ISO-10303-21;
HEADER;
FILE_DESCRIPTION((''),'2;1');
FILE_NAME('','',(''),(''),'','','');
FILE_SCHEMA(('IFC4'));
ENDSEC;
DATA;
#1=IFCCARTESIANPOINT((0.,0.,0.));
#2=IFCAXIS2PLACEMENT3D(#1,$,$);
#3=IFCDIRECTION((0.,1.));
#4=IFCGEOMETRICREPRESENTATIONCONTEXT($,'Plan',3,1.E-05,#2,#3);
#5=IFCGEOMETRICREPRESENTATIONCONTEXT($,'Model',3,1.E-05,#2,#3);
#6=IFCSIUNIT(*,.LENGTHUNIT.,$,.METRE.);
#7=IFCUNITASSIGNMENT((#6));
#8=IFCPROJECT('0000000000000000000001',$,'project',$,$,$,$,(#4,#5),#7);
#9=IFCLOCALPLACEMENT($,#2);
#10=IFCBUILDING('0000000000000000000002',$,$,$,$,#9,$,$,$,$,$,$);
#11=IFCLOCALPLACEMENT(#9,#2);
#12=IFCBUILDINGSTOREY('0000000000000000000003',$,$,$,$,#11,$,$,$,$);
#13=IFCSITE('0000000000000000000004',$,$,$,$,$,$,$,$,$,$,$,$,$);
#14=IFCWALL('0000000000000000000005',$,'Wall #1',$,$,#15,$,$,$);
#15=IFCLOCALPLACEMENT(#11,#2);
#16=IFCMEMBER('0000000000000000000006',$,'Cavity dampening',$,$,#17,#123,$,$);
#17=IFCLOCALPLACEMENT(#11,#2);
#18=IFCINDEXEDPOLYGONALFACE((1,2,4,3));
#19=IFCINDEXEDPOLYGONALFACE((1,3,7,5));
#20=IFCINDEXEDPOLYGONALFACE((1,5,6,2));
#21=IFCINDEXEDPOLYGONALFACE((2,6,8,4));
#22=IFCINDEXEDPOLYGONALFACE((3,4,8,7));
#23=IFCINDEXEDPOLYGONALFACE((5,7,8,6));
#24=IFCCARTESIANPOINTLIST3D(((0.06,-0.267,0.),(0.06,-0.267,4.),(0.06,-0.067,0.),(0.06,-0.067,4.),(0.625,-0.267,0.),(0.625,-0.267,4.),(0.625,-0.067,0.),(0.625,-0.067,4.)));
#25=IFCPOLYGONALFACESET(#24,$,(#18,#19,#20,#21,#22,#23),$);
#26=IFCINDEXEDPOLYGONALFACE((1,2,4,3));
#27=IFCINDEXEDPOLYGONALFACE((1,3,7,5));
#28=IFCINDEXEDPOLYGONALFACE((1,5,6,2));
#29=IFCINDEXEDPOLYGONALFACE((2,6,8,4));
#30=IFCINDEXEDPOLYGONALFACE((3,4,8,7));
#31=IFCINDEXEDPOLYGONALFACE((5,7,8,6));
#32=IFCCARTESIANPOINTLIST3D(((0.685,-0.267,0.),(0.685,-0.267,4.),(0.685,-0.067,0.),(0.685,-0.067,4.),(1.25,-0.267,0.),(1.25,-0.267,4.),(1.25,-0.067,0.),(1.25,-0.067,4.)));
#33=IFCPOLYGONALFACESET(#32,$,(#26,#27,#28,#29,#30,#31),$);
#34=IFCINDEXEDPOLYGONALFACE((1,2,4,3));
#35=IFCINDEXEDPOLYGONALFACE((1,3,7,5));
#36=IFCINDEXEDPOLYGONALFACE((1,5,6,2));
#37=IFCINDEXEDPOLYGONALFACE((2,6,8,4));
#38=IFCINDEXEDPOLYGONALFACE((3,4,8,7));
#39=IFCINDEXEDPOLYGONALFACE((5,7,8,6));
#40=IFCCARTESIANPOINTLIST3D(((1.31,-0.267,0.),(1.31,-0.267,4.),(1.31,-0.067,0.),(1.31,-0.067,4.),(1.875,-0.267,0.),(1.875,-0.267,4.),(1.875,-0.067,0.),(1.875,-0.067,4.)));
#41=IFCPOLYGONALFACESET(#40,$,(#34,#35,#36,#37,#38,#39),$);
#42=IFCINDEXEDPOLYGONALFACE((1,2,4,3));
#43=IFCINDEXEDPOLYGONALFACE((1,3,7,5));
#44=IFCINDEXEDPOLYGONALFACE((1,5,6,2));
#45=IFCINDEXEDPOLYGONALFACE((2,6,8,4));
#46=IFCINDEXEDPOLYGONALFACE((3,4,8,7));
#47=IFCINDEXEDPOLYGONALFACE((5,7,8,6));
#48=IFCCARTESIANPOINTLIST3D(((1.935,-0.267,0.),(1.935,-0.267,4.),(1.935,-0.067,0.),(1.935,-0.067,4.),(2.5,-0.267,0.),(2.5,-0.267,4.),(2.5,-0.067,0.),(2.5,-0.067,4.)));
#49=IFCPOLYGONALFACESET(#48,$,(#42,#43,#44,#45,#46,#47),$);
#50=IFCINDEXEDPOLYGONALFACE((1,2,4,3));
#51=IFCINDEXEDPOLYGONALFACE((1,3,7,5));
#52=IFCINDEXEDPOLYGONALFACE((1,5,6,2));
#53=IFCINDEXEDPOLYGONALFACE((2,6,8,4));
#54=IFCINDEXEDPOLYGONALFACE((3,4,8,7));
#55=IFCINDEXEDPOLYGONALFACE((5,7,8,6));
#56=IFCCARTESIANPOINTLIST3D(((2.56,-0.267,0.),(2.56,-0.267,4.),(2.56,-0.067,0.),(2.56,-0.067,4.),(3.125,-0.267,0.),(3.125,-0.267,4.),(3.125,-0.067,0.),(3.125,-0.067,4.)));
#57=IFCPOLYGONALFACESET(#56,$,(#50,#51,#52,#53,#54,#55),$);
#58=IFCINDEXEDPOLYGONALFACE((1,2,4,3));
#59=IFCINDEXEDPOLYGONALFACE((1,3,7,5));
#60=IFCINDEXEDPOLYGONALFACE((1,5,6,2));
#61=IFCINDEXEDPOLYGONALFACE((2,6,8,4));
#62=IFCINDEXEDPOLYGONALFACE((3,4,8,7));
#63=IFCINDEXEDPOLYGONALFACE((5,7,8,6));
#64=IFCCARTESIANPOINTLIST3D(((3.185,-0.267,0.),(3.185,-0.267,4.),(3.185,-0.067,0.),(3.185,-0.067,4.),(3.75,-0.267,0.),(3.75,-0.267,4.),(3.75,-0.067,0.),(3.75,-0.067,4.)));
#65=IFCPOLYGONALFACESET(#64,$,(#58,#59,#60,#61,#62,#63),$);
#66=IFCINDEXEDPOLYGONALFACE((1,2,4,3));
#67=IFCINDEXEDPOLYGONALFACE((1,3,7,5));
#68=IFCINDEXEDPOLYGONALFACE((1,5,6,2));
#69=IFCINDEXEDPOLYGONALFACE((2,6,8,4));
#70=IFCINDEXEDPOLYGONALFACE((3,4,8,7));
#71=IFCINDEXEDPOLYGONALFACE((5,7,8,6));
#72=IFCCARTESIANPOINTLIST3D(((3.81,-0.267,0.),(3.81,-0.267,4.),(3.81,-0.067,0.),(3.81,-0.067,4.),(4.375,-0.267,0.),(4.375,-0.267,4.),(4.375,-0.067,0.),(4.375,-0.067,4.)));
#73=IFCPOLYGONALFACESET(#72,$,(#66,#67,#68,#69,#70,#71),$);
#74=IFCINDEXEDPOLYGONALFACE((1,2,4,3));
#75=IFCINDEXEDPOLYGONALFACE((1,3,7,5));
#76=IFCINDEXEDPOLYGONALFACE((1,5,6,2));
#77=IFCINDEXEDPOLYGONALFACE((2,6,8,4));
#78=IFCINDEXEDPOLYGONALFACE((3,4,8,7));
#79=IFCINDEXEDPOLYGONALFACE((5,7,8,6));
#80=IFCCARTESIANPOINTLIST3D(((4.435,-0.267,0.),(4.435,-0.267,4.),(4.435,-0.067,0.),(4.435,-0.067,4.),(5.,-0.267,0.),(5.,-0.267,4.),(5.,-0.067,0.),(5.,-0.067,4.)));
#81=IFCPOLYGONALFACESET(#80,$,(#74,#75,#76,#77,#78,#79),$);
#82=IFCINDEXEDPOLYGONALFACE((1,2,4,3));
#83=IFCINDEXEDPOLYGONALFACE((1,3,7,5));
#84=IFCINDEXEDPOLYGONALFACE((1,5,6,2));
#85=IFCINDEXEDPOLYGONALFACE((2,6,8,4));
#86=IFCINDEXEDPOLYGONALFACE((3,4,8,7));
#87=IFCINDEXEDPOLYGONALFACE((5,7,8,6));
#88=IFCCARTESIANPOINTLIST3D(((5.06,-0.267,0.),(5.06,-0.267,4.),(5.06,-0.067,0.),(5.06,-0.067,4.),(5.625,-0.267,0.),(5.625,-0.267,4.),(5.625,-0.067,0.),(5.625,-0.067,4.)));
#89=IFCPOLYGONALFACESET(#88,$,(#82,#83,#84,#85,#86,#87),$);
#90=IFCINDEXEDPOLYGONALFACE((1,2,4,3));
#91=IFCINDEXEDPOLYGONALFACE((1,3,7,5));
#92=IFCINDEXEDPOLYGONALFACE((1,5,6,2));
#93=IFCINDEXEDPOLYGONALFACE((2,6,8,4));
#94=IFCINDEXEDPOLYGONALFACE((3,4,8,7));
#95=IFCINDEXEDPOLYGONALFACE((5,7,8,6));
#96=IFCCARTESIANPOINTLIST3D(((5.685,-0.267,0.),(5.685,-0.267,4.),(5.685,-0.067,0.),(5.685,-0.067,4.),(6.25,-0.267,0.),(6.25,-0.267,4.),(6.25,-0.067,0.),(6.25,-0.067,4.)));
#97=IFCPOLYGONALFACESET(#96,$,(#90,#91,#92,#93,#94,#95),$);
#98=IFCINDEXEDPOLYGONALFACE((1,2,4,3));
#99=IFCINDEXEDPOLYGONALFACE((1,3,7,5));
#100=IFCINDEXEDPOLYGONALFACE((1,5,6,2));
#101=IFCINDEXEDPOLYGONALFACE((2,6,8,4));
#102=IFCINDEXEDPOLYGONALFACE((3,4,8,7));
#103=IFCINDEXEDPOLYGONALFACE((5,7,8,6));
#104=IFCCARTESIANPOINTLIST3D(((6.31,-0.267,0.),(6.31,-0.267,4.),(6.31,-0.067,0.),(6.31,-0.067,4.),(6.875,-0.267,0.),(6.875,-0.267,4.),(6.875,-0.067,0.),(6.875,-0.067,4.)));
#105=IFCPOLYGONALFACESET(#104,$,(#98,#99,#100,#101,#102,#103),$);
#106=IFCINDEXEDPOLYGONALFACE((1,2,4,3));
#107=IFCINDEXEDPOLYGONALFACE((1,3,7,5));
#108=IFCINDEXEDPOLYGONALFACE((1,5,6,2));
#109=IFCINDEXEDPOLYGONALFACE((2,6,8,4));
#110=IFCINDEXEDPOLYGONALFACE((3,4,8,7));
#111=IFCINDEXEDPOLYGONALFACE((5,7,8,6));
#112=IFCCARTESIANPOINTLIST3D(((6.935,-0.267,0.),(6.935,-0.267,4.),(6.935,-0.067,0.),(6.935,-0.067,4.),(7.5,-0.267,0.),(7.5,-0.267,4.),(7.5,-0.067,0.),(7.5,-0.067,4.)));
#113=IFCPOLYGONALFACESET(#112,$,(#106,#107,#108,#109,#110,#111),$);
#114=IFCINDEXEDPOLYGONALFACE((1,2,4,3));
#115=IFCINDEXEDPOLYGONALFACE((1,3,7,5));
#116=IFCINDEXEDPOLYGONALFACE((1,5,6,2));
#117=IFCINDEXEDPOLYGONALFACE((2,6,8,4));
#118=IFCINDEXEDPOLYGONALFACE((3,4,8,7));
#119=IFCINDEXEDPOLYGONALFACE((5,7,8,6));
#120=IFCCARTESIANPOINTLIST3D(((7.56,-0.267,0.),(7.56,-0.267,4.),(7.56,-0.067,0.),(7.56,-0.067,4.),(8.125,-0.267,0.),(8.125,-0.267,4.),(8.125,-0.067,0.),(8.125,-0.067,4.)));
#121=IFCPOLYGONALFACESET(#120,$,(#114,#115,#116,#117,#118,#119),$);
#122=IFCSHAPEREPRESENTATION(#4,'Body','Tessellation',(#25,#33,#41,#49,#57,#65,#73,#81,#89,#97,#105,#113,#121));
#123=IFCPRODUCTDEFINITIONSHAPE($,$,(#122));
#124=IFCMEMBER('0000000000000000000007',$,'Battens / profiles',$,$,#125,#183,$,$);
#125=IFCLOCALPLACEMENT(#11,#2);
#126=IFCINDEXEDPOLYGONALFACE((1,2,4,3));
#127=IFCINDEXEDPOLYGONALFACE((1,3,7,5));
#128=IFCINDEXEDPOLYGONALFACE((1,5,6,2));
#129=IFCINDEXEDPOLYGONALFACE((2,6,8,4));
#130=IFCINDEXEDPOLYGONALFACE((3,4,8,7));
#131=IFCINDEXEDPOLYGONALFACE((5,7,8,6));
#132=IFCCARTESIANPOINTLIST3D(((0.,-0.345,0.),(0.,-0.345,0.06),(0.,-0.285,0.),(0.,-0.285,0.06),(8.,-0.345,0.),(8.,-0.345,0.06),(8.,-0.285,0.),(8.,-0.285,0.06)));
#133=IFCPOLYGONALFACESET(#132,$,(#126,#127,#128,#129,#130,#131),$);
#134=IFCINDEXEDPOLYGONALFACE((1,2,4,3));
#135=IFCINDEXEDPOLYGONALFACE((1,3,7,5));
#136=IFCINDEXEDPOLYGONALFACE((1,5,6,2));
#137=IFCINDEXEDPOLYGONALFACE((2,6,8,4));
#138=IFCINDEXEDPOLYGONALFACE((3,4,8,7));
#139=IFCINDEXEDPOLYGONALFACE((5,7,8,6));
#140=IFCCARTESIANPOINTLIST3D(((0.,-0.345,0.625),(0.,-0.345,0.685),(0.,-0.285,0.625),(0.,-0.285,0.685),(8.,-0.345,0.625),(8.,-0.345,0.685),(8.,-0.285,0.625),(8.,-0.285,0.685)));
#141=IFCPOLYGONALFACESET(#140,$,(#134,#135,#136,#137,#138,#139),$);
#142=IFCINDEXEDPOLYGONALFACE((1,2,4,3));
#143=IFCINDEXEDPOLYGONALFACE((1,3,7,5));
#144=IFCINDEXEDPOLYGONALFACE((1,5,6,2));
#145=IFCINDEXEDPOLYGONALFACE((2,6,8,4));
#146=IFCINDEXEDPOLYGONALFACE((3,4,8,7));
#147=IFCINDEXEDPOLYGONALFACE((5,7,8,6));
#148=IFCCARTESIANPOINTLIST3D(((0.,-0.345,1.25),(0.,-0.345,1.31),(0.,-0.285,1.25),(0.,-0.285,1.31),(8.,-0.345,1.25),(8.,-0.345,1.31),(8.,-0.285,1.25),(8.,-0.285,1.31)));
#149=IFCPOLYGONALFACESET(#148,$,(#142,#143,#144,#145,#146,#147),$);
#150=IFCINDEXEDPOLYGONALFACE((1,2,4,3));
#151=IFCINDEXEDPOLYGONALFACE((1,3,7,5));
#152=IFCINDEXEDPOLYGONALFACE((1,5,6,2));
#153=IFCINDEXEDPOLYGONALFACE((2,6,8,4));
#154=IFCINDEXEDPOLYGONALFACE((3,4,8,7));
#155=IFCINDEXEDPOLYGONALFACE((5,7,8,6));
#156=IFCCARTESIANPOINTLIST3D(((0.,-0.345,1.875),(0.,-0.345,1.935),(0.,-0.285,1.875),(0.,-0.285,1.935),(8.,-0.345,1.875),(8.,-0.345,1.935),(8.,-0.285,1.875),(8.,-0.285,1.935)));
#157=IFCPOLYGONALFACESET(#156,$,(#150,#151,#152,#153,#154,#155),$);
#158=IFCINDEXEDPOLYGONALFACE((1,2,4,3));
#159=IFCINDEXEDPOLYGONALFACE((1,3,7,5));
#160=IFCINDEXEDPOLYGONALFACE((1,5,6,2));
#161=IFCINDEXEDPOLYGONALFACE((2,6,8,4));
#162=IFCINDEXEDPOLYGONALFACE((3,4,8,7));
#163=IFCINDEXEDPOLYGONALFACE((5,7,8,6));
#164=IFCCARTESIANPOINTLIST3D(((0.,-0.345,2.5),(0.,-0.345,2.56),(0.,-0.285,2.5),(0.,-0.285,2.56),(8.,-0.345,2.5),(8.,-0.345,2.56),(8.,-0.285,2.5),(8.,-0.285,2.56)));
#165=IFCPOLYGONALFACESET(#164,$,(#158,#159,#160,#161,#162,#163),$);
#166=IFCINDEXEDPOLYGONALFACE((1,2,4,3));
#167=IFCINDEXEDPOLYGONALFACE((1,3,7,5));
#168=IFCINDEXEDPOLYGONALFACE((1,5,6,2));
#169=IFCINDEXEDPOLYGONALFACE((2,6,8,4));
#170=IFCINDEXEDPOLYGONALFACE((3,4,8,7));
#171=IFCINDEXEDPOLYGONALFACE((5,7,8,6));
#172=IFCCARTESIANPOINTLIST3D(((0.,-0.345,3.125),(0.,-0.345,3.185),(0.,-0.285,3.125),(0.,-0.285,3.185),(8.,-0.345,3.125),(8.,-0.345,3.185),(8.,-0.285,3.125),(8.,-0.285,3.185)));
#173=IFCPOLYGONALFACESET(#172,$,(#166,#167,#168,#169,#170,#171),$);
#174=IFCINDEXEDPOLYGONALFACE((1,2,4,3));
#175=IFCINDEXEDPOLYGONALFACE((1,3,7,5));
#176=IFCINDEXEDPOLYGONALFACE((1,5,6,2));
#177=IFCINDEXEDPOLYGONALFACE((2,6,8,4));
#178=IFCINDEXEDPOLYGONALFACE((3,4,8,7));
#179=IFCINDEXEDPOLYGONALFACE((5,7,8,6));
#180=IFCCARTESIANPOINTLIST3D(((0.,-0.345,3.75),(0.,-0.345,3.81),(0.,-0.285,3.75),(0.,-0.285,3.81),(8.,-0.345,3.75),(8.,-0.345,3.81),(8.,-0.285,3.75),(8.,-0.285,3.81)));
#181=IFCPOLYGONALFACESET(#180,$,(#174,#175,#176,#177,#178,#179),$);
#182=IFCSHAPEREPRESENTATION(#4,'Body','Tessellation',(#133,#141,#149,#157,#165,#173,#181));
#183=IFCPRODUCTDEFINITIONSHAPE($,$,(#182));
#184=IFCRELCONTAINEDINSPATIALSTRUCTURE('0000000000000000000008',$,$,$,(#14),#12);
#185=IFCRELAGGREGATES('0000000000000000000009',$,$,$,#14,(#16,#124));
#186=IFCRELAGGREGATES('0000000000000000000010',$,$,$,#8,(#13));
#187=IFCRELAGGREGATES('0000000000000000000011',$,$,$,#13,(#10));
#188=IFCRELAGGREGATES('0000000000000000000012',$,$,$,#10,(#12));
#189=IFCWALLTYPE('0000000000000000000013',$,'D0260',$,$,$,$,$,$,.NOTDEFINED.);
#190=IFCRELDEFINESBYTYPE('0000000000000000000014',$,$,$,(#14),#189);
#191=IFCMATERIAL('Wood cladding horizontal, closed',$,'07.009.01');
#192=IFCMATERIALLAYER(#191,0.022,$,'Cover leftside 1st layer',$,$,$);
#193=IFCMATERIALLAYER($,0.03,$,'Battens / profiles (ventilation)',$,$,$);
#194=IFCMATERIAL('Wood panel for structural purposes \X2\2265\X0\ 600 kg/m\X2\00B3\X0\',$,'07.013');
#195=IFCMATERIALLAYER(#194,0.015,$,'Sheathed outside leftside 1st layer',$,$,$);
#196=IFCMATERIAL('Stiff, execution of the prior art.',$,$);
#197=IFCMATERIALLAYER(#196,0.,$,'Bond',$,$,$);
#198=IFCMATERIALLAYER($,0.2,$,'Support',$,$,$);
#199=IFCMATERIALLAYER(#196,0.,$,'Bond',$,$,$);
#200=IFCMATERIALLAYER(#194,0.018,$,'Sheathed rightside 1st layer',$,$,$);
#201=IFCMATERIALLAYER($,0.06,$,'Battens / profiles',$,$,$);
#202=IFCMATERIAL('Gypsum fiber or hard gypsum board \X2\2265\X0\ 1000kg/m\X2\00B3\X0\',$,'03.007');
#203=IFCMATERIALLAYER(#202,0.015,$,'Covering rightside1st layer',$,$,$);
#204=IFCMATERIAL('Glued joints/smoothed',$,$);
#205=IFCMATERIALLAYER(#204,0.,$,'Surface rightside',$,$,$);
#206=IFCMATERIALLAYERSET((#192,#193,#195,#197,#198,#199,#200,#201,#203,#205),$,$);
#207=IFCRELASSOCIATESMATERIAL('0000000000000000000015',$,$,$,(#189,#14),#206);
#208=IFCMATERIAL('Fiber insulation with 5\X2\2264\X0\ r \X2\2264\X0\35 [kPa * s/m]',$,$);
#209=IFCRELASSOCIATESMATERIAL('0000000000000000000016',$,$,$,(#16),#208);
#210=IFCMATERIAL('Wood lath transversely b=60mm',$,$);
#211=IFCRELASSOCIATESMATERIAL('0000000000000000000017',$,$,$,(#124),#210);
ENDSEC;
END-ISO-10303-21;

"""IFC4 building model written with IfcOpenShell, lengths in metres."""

from ifc_helpers import new_model, si_unit, direction, frame, frame_2d, origin, place, context, project, spatial, rectangle, extrude, material, layer, layer_set, type_object, element, aggregate, save


model = new_model("IFC4")

# Units and contexts
plan_context = context("Plan", 3, precision=1e-05, world=origin(), true_north=direction((0.0, 1.0)))
model_context = context("Model", 3, precision=1e-05, world=origin(), true_north=direction((0.0, 1.0)))
ifc_project = project(units=[si_unit("LENGTHUNIT", "METRE")], contexts=[plan_context, model_context])

# Site, building, storey
site = spatial("IfcSite", under=ifc_project)
building_placement = place(None, origin())
building = spatial("IfcBuilding", under=site, at=building_placement)
storey_placement = place(building_placement, origin())
storey = spatial("IfcBuildingStorey", under=building, at=storey_placement)

# Wall, members
ifc_material_1 = material(Name="Wood cladding horizontal, closed", Category="07.009.01")
ifc_layer_1 = layer(ifc_material_1, 0.022, Name="Cover leftside 1st layer")
ifc_layer_2 = layer(None, 0.03, Name="Battens / profiles (ventilation)")
ifc_material_2 = material(Name="Wood panel for structural purposes ≥ 600 kg/m³", Category="07.013")
ifc_layer_3 = layer(ifc_material_2, 0.015, Name="Sheathed outside leftside 1st layer")
ifc_material_3 = material(Name="Stiff, execution of the prior art.")
ifc_layer_4 = layer(ifc_material_3, 0.0, Name="Bond")
ifc_layer_5 = layer(None, 0.2, Name="Support")
ifc_layer_6 = layer(ifc_material_3, 0.0, Name="Bond")
ifc_layer_7 = layer(ifc_material_2, 0.018, Name="Sheathed rightside 1st layer")
ifc_layer_8 = layer(None, 0.06, Name="Battens / profiles")
ifc_material_4 = material(Name="Gypsum fiber or hard gypsum board ≥ 1000kg/m³", Category="03.007")
ifc_layer_9 = layer(ifc_material_4, 0.015, Name="Covering rightside1st layer")
ifc_material_5 = material(Name="Glued joints/smoothed")
ifc_layer_10 = layer(ifc_material_5, 0.0, Name="Surface rightside")
ifc_layer_set = layer_set([ifc_layer_1, ifc_layer_2, ifc_layer_3, ifc_layer_4, ifc_layer_5, ifc_layer_6, ifc_layer_7, ifc_layer_8, ifc_layer_9, ifc_layer_10])
wall_type = type_object("IfcWallType", Name="D0260", PredefinedType="NOTDEFINED", material=ifc_layer_set)
wall_placement = place(None, frame((0.0, 0.0, 0.0), z_axis=(0.0, -1.0, 0.0), x_axis=(1.0, 0.0, 0.0)))
wall = element("IfcWall", 1, at=wall_placement, inside=storey, type_object=wall_type, material=ifc_layer_set, Name="Wall #1")
ifc_material_6 = material(Name="Fiber insulation with 5≤ r ≤35 [kPa * s/m]")
member_1_placement = place(wall_placement, origin())
member_1 = element("IfcMember", 2, at=member_1_placement, material=ifc_material_6, Name="Cavity dampening", context=plan_context, shape_type="SweptSolid", body=[
    extrude(rectangle(XDim=0.565, YDim=0.2, at=frame_2d((0.2825, 0.1), x_axis=(1.0, 0.0))), frame((0.06, 4.0, 0.067), z_axis=(0.0, -1.0, 0.0), x_axis=(1.0, 0.0, 0.0)), (0.0, 0.0, 1.0), 4.0),
    extrude(rectangle(XDim=0.565, YDim=0.2, at=frame_2d((0.2825, 0.1), x_axis=(1.0, 0.0))), frame((0.685, 4.0, 0.067), z_axis=(0.0, -1.0, 0.0), x_axis=(1.0, 0.0, 0.0)), (0.0, 0.0, 1.0), 4.0),
    extrude(rectangle(XDim=0.565, YDim=0.2, at=frame_2d((0.2825, 0.1), x_axis=(1.0, 0.0))), frame((1.31, 4.0, 0.067), z_axis=(0.0, -1.0, 0.0), x_axis=(1.0, 0.0, 0.0)), (0.0, 0.0, 1.0), 4.0),
    extrude(rectangle(XDim=0.565, YDim=0.2, at=frame_2d((0.2825, 0.1), x_axis=(1.0, 0.0))), frame((1.935, 4.0, 0.067), z_axis=(0.0, -1.0, 0.0), x_axis=(1.0, 0.0, 0.0)), (0.0, 0.0, 1.0), 4.0),
    extrude(rectangle(XDim=0.565, YDim=0.2, at=frame_2d((0.2825, 0.1), x_axis=(1.0, 0.0))), frame((2.56, 4.0, 0.067), z_axis=(0.0, -1.0, 0.0), x_axis=(1.0, 0.0, 0.0)), (0.0, 0.0, 1.0), 4.0),
    extrude(rectangle(XDim=0.565, YDim=0.2, at=frame_2d((0.2825, 0.1), x_axis=(1.0, 0.0))), frame((3.185, 4.0, 0.067), z_axis=(0.0, -1.0, 0.0), x_axis=(1.0, 0.0, 0.0)), (0.0, 0.0, 1.0), 4.0),
    extrude(rectangle(XDim=0.565, YDim=0.2, at=frame_2d((0.2825, 0.1), x_axis=(1.0, 0.0))), frame((3.81, 4.0, 0.067), z_axis=(0.0, -1.0, 0.0), x_axis=(1.0, 0.0, 0.0)), (0.0, 0.0, 1.0), 4.0),
    extrude(rectangle(XDim=0.565, YDim=0.2, at=frame_2d((0.2825, 0.1), x_axis=(1.0, 0.0))), frame((4.435, 4.0, 0.067), z_axis=(0.0, -1.0, 0.0), x_axis=(1.0, 0.0, 0.0)), (0.0, 0.0, 1.0), 4.0),
    extrude(rectangle(XDim=0.565, YDim=0.2, at=frame_2d((0.2825, 0.1), x_axis=(1.0, 0.0))), frame((5.06, 4.0, 0.067), z_axis=(0.0, -1.0, 0.0), x_axis=(1.0, 0.0, 0.0)), (0.0, 0.0, 1.0), 4.0),
    extrude(rectangle(XDim=0.565, YDim=0.2, at=frame_2d((0.2825, 0.1), x_axis=(1.0, 0.0))), frame((5.685, 4.0, 0.067), z_axis=(0.0, -1.0, 0.0), x_axis=(1.0, 0.0, 0.0)), (0.0, 0.0, 1.0), 4.0),
    extrude(rectangle(XDim=0.565, YDim=0.2, at=frame_2d((0.2825, 0.1), x_axis=(1.0, 0.0))), frame((6.31, 4.0, 0.067), z_axis=(0.0, -1.0, 0.0), x_axis=(1.0, 0.0, 0.0)), (0.0, 0.0, 1.0), 4.0),
    extrude(rectangle(XDim=0.565, YDim=0.2, at=frame_2d((0.2825, 0.1), x_axis=(1.0, 0.0))), frame((6.935, 4.0, 0.067), z_axis=(0.0, -1.0, 0.0), x_axis=(1.0, 0.0, 0.0)), (0.0, 0.0, 1.0), 4.0),
    extrude(rectangle(XDim=0.565, YDim=0.2, at=frame_2d((0.2825, 0.1), x_axis=(1.0, 0.0))), frame((7.56, 4.0, 0.067), z_axis=(0.0, -1.0, 0.0), x_axis=(1.0, 0.0, 0.0)), (0.0, 0.0, 1.0), 4.0),
])
ifc_material_7 = material(Name="Wood lath transversely b=60mm")
member_2_placement = place(wall_placement, origin())
member_2 = element("IfcMember", 3, at=member_2_placement, material=ifc_material_7, Name="Battens / profiles", context=plan_context, shape_type="SweptSolid", body=[
    extrude(rectangle(XDim=0.06, YDim=0.06, at=frame_2d((0.03, 0.03), x_axis=(1.0, 0.0))), frame((0.0, 0.0, 0.285), z_axis=(1.0, 0.0, 0.0), x_axis=(0.0, 1.0, 0.0)), (0.0, 0.0, 1.0), 8.0),
    extrude(rectangle(XDim=0.06, YDim=0.06, at=frame_2d((0.03, 0.03), x_axis=(1.0, 0.0))), frame((0.0, 0.625, 0.285), z_axis=(1.0, 0.0, 0.0), x_axis=(0.0, 1.0, 0.0)), (0.0, 0.0, 1.0), 8.0),
    extrude(rectangle(XDim=0.06, YDim=0.06, at=frame_2d((0.03, 0.03), x_axis=(1.0, 0.0))), frame((0.0, 1.25, 0.285), z_axis=(1.0, 0.0, 0.0), x_axis=(0.0, 1.0, 0.0)), (0.0, 0.0, 1.0), 8.0),
    extrude(rectangle(XDim=0.06, YDim=0.06, at=frame_2d((0.03, 0.03), x_axis=(1.0, 0.0))), frame((0.0, 1.875, 0.285), z_axis=(1.0, 0.0, 0.0), x_axis=(0.0, 1.0, 0.0)), (0.0, 0.0, 1.0), 8.0),
    extrude(rectangle(XDim=0.06, YDim=0.06, at=frame_2d((0.03, 0.03), x_axis=(1.0, 0.0))), frame((0.0, 2.5, 0.285), z_axis=(1.0, 0.0, 0.0), x_axis=(0.0, 1.0, 0.0)), (0.0, 0.0, 1.0), 8.0),
    extrude(rectangle(XDim=0.06, YDim=0.06, at=frame_2d((0.03, 0.03), x_axis=(1.0, 0.0))), frame((0.0, 3.125, 0.285), z_axis=(1.0, 0.0, 0.0), x_axis=(0.0, 1.0, 0.0)), (0.0, 0.0, 1.0), 8.0),
    extrude(rectangle(XDim=0.06, YDim=0.06, at=frame_2d((0.03, 0.03), x_axis=(1.0, 0.0))), frame((0.0, 3.75, 0.285), z_axis=(1.0, 0.0, 0.0), x_axis=(0.0, 1.0, 0.0)), (0.0, 0.0, 1.0), 8.0),
])
aggregate(wall, [member_1, member_2])

save(model, "model.ifc")
